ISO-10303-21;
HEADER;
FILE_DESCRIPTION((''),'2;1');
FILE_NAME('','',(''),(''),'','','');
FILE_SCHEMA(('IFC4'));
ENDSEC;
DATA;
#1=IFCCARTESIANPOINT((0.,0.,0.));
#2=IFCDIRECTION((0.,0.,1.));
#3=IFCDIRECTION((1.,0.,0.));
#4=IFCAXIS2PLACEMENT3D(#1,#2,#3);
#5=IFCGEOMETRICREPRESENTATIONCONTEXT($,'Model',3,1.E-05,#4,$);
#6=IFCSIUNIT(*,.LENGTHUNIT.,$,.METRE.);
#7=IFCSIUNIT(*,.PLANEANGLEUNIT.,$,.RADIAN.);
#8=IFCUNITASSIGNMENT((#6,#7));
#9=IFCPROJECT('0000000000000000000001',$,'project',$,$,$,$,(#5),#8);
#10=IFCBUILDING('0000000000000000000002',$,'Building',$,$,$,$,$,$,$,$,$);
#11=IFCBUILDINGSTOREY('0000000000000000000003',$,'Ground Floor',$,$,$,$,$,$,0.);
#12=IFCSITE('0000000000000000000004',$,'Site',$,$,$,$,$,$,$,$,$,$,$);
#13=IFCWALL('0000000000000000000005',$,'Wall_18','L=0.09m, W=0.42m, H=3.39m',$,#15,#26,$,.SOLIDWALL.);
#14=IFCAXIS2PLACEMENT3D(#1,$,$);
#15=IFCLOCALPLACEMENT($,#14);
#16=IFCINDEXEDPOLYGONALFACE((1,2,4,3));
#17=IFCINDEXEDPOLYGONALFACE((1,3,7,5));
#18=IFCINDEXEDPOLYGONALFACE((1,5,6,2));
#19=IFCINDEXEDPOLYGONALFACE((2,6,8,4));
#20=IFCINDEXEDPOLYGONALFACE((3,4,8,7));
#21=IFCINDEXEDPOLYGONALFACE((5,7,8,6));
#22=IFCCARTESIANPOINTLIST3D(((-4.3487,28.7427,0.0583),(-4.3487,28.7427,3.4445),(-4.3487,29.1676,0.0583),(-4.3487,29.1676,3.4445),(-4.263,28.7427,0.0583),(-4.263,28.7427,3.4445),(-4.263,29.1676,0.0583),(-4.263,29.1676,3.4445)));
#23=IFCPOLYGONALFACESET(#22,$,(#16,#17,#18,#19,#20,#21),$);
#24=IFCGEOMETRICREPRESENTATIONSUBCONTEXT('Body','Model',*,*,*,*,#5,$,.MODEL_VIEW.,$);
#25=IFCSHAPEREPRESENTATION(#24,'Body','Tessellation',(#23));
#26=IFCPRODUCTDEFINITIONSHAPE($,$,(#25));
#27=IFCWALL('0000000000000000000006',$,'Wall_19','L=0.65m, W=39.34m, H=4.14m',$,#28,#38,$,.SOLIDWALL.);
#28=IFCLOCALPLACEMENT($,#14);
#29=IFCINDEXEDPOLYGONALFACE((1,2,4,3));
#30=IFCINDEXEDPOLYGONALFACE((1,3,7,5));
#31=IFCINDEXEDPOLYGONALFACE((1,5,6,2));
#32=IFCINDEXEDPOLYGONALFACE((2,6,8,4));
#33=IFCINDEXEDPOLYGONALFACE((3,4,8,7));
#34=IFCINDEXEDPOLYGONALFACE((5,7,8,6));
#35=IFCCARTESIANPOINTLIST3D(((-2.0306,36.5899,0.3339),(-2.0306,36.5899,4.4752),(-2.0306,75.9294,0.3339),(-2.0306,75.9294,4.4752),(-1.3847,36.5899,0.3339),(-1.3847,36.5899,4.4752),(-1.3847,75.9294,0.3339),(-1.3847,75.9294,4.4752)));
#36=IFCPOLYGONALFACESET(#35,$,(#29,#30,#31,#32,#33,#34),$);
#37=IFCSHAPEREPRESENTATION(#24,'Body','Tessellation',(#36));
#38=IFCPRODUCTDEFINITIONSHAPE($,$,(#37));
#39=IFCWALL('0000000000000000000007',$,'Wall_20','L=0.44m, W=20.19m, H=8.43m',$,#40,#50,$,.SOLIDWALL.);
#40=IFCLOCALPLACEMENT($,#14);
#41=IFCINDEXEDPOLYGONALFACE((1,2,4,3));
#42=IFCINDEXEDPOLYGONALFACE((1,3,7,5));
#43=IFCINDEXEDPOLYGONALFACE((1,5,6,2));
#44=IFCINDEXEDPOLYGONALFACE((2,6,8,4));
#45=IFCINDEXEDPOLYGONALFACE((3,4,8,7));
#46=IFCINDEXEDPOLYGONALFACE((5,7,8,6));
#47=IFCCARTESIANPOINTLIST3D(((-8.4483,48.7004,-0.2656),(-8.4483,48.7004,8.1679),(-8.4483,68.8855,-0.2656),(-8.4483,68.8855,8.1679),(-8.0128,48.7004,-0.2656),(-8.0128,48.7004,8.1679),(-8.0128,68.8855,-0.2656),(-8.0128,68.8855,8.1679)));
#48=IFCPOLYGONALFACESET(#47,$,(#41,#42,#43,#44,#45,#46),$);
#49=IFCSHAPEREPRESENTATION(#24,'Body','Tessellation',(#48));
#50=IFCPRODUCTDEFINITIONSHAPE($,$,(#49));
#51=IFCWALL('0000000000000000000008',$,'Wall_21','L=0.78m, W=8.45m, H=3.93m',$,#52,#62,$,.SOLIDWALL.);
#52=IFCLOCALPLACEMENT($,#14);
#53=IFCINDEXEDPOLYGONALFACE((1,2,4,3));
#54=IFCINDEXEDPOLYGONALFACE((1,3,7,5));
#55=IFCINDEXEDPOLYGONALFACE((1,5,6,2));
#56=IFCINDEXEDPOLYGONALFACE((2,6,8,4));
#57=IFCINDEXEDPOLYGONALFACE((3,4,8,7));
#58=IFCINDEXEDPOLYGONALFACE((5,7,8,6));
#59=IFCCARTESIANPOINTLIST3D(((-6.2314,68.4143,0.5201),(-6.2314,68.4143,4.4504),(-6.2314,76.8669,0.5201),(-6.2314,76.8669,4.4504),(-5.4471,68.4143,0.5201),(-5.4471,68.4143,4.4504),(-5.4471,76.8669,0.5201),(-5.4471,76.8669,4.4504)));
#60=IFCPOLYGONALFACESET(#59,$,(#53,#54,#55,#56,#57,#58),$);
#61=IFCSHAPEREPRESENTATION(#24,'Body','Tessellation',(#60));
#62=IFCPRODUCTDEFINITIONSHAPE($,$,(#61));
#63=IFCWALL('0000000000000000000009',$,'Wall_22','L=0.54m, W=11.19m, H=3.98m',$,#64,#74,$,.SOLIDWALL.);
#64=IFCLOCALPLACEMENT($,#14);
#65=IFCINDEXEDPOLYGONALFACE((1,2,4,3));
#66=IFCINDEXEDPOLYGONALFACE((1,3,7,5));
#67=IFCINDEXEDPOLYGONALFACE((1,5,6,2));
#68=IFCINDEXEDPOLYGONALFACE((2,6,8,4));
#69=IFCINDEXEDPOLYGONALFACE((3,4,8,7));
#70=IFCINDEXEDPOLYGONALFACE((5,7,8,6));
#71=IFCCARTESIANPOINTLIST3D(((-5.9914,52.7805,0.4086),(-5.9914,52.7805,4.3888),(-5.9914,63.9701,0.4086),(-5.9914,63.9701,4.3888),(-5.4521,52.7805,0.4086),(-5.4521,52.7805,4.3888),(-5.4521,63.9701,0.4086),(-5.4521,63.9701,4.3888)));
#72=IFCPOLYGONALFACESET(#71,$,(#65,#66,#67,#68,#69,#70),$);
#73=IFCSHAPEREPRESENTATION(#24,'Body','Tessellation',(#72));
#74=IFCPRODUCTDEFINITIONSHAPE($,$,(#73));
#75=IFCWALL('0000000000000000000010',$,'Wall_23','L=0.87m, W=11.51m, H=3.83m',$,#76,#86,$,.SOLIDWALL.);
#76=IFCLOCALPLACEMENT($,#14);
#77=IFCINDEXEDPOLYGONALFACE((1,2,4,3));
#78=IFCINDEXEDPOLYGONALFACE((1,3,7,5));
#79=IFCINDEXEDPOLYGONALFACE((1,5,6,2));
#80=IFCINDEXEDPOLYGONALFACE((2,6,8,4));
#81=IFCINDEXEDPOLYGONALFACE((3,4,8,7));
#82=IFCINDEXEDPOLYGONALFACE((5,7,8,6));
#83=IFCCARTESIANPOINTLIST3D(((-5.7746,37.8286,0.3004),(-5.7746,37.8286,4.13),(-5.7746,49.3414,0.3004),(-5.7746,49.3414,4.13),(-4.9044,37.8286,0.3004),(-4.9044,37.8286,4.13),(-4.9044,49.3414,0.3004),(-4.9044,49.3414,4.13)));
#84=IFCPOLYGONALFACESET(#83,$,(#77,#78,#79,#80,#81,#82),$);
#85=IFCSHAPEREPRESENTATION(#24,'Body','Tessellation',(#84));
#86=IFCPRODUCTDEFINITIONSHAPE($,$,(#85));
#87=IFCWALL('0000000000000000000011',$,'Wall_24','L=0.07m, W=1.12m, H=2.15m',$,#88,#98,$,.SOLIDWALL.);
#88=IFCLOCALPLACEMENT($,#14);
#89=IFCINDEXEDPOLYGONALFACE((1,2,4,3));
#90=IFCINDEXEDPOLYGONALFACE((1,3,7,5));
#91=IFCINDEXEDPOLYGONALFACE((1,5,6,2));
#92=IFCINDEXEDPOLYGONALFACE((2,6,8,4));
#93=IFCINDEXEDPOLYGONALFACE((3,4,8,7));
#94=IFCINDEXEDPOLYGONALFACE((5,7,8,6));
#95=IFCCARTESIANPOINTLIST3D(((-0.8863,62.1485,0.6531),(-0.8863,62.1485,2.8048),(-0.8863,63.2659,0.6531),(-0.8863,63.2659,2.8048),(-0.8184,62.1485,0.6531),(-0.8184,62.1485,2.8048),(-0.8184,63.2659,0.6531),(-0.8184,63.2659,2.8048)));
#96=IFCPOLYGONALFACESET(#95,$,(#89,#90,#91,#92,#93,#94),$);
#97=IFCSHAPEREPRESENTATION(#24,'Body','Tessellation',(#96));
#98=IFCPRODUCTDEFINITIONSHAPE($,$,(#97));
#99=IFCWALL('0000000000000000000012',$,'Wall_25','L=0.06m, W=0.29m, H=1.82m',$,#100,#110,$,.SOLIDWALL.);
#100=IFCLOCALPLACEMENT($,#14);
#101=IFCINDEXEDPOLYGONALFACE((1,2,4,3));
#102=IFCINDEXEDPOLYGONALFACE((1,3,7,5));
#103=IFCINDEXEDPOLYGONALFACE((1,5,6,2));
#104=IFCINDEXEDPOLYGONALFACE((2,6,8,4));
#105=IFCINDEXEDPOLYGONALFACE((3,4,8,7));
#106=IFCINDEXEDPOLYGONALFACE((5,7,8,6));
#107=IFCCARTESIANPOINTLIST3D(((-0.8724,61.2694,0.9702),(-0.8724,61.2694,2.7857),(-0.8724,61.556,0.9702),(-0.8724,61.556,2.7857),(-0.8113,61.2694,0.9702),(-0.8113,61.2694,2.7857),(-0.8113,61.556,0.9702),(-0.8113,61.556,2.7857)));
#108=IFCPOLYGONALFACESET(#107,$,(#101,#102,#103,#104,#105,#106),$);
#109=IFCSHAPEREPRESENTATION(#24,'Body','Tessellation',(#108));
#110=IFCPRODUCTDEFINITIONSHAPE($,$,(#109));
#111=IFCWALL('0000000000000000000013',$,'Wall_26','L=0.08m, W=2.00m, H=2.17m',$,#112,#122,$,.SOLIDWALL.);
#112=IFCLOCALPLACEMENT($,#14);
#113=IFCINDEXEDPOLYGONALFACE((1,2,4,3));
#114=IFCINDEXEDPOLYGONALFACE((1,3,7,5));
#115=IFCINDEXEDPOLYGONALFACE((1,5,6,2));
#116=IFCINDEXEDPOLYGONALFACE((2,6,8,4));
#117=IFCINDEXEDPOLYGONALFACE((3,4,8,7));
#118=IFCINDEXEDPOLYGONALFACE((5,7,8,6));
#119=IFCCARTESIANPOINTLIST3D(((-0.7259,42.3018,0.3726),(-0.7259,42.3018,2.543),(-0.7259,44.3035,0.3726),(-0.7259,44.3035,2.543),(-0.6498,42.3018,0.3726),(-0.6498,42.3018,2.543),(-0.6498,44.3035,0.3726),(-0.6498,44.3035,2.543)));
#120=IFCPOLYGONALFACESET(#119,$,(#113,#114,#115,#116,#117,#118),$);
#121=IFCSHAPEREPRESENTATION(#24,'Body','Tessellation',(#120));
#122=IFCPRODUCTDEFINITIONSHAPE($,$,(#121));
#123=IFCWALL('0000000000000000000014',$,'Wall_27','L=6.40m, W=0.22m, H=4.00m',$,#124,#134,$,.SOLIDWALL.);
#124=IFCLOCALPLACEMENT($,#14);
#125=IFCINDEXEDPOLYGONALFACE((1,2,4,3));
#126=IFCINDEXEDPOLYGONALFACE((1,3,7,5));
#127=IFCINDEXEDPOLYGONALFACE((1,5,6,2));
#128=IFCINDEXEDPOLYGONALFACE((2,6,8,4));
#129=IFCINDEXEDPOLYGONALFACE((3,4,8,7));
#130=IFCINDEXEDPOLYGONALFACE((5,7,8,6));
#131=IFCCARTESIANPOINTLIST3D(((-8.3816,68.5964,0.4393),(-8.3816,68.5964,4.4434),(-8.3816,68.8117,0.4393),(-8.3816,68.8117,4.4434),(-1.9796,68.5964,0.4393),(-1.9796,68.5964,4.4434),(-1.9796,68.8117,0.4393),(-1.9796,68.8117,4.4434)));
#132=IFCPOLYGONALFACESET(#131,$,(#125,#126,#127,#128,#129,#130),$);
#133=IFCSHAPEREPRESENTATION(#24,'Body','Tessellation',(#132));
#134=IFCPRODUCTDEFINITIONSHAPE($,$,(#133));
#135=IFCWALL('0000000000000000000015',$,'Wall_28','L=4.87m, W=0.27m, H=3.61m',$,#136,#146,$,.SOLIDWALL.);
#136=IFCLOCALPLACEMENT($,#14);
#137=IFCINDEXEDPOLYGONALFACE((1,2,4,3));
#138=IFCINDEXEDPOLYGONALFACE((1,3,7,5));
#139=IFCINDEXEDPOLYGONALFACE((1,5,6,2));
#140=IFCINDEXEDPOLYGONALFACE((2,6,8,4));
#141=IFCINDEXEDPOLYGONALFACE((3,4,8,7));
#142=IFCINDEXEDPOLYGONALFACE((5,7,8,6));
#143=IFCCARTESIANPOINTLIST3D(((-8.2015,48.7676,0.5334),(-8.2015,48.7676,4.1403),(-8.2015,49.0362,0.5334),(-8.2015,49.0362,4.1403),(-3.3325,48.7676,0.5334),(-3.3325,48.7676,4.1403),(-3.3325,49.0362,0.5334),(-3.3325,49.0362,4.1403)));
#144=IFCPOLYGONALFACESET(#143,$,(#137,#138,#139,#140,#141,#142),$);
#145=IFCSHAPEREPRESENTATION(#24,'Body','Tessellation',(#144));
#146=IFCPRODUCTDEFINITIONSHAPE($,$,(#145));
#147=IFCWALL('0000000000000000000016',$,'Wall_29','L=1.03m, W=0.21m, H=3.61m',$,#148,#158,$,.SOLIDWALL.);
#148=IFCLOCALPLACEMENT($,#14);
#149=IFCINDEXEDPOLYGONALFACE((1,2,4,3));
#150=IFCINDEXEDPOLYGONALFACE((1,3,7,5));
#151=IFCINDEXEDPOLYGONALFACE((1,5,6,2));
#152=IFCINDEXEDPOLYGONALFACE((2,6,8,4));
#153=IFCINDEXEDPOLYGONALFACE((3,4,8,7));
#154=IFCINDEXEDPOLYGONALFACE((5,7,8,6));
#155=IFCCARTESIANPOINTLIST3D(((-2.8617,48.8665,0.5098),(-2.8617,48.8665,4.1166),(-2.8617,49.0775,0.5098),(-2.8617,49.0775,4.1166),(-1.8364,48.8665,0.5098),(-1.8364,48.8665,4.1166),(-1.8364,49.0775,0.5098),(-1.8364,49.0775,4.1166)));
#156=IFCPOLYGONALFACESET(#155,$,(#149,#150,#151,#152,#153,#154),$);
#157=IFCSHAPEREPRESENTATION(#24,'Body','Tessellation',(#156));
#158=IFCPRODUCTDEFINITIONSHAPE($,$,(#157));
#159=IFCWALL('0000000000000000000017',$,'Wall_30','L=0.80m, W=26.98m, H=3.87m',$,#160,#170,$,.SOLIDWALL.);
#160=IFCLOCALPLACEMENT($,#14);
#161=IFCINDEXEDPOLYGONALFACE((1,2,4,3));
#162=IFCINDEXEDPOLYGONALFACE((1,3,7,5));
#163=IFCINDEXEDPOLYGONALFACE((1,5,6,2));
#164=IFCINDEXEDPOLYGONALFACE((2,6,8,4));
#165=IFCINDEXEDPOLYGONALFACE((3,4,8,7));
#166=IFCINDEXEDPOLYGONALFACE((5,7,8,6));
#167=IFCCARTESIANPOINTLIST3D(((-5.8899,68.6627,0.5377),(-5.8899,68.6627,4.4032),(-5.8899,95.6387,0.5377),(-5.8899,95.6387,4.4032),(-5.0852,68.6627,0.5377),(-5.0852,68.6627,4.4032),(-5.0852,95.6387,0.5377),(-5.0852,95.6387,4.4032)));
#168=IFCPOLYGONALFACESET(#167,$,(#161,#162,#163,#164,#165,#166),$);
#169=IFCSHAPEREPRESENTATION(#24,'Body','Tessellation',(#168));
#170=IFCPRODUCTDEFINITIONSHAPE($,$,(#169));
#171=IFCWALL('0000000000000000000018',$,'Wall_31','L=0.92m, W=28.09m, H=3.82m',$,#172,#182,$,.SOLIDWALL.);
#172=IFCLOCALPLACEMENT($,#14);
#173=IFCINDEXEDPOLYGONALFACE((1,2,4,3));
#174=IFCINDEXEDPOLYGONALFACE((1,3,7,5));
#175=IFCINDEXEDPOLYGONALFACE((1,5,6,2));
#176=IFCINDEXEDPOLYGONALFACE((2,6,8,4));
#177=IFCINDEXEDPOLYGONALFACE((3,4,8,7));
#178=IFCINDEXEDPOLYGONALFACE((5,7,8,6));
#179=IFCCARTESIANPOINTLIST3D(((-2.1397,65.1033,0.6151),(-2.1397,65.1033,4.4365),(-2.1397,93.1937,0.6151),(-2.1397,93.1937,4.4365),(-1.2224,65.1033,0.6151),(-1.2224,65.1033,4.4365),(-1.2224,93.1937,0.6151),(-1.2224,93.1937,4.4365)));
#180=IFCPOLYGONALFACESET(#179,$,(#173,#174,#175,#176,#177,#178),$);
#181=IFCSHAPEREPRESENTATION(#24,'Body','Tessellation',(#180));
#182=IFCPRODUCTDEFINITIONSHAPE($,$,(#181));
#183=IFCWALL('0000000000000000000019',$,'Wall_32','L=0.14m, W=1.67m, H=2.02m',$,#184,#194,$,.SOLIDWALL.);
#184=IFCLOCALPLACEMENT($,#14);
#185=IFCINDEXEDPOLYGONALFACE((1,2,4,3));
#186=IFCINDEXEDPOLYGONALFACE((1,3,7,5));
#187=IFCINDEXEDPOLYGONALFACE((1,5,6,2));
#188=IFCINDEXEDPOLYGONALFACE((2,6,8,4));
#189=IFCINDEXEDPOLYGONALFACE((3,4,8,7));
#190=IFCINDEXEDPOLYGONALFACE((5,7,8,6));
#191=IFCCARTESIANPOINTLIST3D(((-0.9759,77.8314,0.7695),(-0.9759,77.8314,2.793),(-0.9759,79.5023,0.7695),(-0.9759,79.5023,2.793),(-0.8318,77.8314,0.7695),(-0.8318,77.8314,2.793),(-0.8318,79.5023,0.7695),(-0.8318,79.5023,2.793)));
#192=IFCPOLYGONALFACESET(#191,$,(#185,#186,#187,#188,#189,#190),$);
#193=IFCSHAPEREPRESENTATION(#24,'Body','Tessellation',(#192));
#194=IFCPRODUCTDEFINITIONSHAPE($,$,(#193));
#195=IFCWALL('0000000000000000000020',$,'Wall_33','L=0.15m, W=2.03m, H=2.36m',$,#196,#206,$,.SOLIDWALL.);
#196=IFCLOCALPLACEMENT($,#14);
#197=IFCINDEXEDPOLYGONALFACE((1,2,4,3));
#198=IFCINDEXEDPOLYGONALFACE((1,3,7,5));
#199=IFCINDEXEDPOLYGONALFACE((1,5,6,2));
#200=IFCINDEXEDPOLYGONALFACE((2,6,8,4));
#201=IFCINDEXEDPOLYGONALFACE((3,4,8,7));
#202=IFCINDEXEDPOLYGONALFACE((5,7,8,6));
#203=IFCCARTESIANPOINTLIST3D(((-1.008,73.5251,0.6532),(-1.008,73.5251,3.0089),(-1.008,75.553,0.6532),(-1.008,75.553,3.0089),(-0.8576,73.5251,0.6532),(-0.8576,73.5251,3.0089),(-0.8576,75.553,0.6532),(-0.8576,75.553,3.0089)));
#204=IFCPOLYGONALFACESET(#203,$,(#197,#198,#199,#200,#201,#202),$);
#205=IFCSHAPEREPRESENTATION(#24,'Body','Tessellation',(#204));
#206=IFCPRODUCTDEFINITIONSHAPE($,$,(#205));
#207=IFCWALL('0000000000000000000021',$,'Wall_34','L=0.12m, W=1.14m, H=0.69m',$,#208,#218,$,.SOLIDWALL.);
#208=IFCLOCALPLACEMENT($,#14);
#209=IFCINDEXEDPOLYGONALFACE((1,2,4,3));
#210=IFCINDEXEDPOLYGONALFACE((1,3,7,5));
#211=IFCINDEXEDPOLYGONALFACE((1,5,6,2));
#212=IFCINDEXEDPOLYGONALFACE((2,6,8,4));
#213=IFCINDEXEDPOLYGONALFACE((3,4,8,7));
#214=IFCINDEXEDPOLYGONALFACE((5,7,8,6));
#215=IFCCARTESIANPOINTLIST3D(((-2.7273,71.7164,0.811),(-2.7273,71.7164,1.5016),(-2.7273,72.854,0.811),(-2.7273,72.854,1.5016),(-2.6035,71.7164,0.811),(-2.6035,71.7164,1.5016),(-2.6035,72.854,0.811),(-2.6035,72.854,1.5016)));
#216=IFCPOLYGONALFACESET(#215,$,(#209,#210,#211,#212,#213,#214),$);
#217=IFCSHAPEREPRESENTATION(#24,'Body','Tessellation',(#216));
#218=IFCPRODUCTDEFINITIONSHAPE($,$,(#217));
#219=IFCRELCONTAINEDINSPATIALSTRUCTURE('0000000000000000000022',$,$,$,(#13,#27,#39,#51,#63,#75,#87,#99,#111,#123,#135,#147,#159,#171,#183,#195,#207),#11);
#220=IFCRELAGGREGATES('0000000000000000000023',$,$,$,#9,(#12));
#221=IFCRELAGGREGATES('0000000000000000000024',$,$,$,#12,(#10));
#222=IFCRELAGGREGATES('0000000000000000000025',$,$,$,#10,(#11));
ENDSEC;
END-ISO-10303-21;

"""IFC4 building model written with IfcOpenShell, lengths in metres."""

from ifc_helpers import new_model, si_unit, frame, origin_with_axes, origin_2d, context, subcontext, project, spatial, rectangle, extrude, element, save


model = new_model("IFC4")

# Units and contexts
model_context = context("Model", 3, precision=1e-05, world=origin_with_axes())
body_context = subcontext(model_context, "Body", "Model", "MODEL_VIEW")
ifc_project = project(units=[si_unit("LENGTHUNIT", "METRE"), si_unit("PLANEANGLEUNIT", "RADIAN")], contexts=[model_context])

# Site, building, storey
site = spatial("IfcSite", under=ifc_project, Name="Site")
building = spatial("IfcBuilding", under=site, Name="Building")
storey = spatial("IfcBuildingStorey", under=building, Name="Ground Floor", Elevation=0.0)

# Walls
element("IfcWall", 1, inside=storey, Name="Wall_18", Description="L=0.09m, W=0.42m, H=3.39m", PredefinedType="SOLIDWALL", context=body_context, shape_type="SweptSolid", body=[
    extrude(rectangle(XDim=0.0857, YDim=0.4249, at=origin_2d()), frame((-4.3058, 28.9551, 0.0583), z_axis=(0.0, 0.0, 1.0), x_axis=(1.0, 0.0, 0.0)), (0.0, 0.0, 1.0), 3.3862),
])
element("IfcWall", 2, inside=storey, Name="Wall_19", Description="L=0.65m, W=39.34m, H=4.14m", PredefinedType="SOLIDWALL", context=body_context, shape_type="SweptSolid", body=[
    extrude(rectangle(XDim=0.6459, YDim=39.3394, at=origin_2d()), frame((-1.7077, 56.2597, 0.3339), z_axis=(0.0, 0.0, 1.0), x_axis=(1.0, 0.0, 0.0)), (0.0, 0.0, 1.0), 4.1413),
])
element("IfcWall", 3, inside=storey, Name="Wall_20", Description="L=0.44m, W=20.19m, H=8.43m", PredefinedType="SOLIDWALL", context=body_context, shape_type="SweptSolid", body=[
    extrude(rectangle(XDim=0.4355, YDim=20.1851, at=origin_2d()), frame((-8.2305, 58.7929, -0.2656), z_axis=(0.0, 0.0, 1.0), x_axis=(1.0, 0.0, 0.0)), (0.0, 0.0, 1.0), 8.4335),
])
element("IfcWall", 4, inside=storey, Name="Wall_21", Description="L=0.78m, W=8.45m, H=3.93m", PredefinedType="SOLIDWALL", context=body_context, shape_type="SweptSolid", body=[
    extrude(rectangle(XDim=0.7843, YDim=8.4526, at=origin_2d()), frame((-5.8392, 72.6406, 0.5201), z_axis=(0.0, 0.0, 1.0), x_axis=(1.0, 0.0, 0.0)), (0.0, 0.0, 1.0), 3.9304),
])
element("IfcWall", 5, inside=storey, Name="Wall_22", Description="L=0.54m, W=11.19m, H=3.98m", PredefinedType="SOLIDWALL", context=body_context, shape_type="SweptSolid", body=[
    extrude(rectangle(XDim=0.5393, YDim=11.1896, at=origin_2d()), frame((-5.7218, 58.3753, 0.4086), z_axis=(0.0, 0.0, 1.0), x_axis=(1.0, 0.0, 0.0)), (0.0, 0.0, 1.0), 3.9801),
])
element("IfcWall", 6, inside=storey, Name="Wall_23", Description="L=0.87m, W=11.51m, H=3.83m", PredefinedType="SOLIDWALL", context=body_context, shape_type="SweptSolid", body=[
    extrude(rectangle(XDim=0.8702, YDim=11.5128, at=origin_2d()), frame((-5.3395, 43.585, 0.3004), z_axis=(0.0, 0.0, 1.0), x_axis=(1.0, 0.0, 0.0)), (0.0, 0.0, 1.0), 3.8297),
])
element("IfcWall", 7, inside=storey, Name="Wall_24", Description="L=0.07m, W=1.12m, H=2.15m", PredefinedType="SOLIDWALL", context=body_context, shape_type="SweptSolid", body=[
    extrude(rectangle(XDim=0.068, YDim=1.1173, at=origin_2d()), frame((-0.8524, 62.7072, 0.6531), z_axis=(0.0, 0.0, 1.0), x_axis=(1.0, 0.0, 0.0)), (0.0, 0.0, 1.0), 2.1517),
])
element("IfcWall", 8, inside=storey, Name="Wall_25", Description="L=0.06m, W=0.29m, H=1.82m", PredefinedType="SOLIDWALL", context=body_context, shape_type="SweptSolid", body=[
    extrude(rectangle(XDim=0.0611, YDim=0.2866, at=origin_2d()), frame((-0.8419, 61.4127, 0.9702), z_axis=(0.0, 0.0, 1.0), x_axis=(1.0, 0.0, 0.0)), (0.0, 0.0, 1.0), 1.8156),
])
element("IfcWall", 9, inside=storey, Name="Wall_26", Description="L=0.08m, W=2.00m, H=2.17m", PredefinedType="SOLIDWALL", context=body_context, shape_type="SweptSolid", body=[
    extrude(rectangle(XDim=0.0761, YDim=2.0017, at=origin_2d()), frame((-0.6879, 43.3026, 0.3726), z_axis=(0.0, 0.0, 1.0), x_axis=(1.0, 0.0, 0.0)), (0.0, 0.0, 1.0), 2.1704),
])
element("IfcWall", 10, inside=storey, Name="Wall_27", Description="L=6.40m, W=0.22m, H=4.00m", PredefinedType="SOLIDWALL", context=body_context, shape_type="SweptSolid", body=[
    extrude(rectangle(XDim=6.4019, YDim=0.2153, at=origin_2d()), frame((-5.1806, 68.704, 0.4393), z_axis=(0.0, 0.0, 1.0), x_axis=(1.0, 0.0, 0.0)), (0.0, 0.0, 1.0), 4.0042),
])
element("IfcWall", 11, inside=storey, Name="Wall_28", Description="L=4.87m, W=0.27m, H=3.61m", PredefinedType="SOLIDWALL", context=body_context, shape_type="SweptSolid", body=[
    extrude(rectangle(XDim=4.869, YDim=0.2687, at=origin_2d()), frame((-5.767, 48.9019, 0.5334), z_axis=(0.0, 0.0, 1.0), x_axis=(1.0, 0.0, 0.0)), (0.0, 0.0, 1.0), 3.6069),
])
element("IfcWall", 12, inside=storey, Name="Wall_29", Description="L=1.03m, W=0.21m, H=3.61m", PredefinedType="SOLIDWALL", context=body_context, shape_type="SweptSolid", body=[
    extrude(rectangle(XDim=1.0253, YDim=0.211, at=origin_2d()), frame((-2.349, 48.972, 0.5098), z_axis=(0.0, 0.0, 1.0), x_axis=(1.0, 0.0, 0.0)), (0.0, 0.0, 1.0), 3.6068),
])
element("IfcWall", 13, inside=storey, Name="Wall_30", Description="L=0.80m, W=26.98m, H=3.87m", PredefinedType="SOLIDWALL", context=body_context, shape_type="SweptSolid", body=[
    extrude(rectangle(XDim=0.8047, YDim=26.976, at=origin_2d()), frame((-5.4875, 82.1507, 0.5377), z_axis=(0.0, 0.0, 1.0), x_axis=(1.0, 0.0, 0.0)), (0.0, 0.0, 1.0), 3.8655),
])
element("IfcWall", 14, inside=storey, Name="Wall_31", Description="L=0.92m, W=28.09m, H=3.82m", PredefinedType="SOLIDWALL", context=body_context, shape_type="SweptSolid", body=[
    extrude(rectangle(XDim=0.9173, YDim=28.0904, at=origin_2d()), frame((-1.681, 79.1485, 0.6151), z_axis=(0.0, 0.0, 1.0), x_axis=(1.0, 0.0, 0.0)), (0.0, 0.0, 1.0), 3.8214),
])
element("IfcWall", 15, inside=storey, Name="Wall_32", Description="L=0.14m, W=1.67m, H=2.02m", PredefinedType="SOLIDWALL", context=body_context, shape_type="SweptSolid", body=[
    extrude(rectangle(XDim=0.1441, YDim=1.6709, at=origin_2d()), frame((-0.9039, 78.6669, 0.7695), z_axis=(0.0, 0.0, 1.0), x_axis=(1.0, 0.0, 0.0)), (0.0, 0.0, 1.0), 2.0235),
])
element("IfcWall", 16, inside=storey, Name="Wall_33", Description="L=0.15m, W=2.03m, H=2.36m", PredefinedType="SOLIDWALL", context=body_context, shape_type="SweptSolid", body=[
    extrude(rectangle(XDim=0.1504, YDim=2.0278, at=origin_2d()), frame((-0.9328, 74.5391, 0.6532), z_axis=(0.0, 0.0, 1.0), x_axis=(1.0, 0.0, 0.0)), (0.0, 0.0, 1.0), 2.3556),
])
element("IfcWall", 17, inside=storey, Name="Wall_34", Description="L=0.12m, W=1.14m, H=0.69m", PredefinedType="SOLIDWALL", context=body_context, shape_type="SweptSolid", body=[
    extrude(rectangle(XDim=0.1238, YDim=1.1376, at=origin_2d()), frame((-2.6654, 72.2852, 0.811), z_axis=(0.0, 0.0, 1.0), x_axis=(1.0, 0.0, 0.0)), (0.0, 0.0, 1.0), 0.6906),
])

save(model, "model.ifc")
